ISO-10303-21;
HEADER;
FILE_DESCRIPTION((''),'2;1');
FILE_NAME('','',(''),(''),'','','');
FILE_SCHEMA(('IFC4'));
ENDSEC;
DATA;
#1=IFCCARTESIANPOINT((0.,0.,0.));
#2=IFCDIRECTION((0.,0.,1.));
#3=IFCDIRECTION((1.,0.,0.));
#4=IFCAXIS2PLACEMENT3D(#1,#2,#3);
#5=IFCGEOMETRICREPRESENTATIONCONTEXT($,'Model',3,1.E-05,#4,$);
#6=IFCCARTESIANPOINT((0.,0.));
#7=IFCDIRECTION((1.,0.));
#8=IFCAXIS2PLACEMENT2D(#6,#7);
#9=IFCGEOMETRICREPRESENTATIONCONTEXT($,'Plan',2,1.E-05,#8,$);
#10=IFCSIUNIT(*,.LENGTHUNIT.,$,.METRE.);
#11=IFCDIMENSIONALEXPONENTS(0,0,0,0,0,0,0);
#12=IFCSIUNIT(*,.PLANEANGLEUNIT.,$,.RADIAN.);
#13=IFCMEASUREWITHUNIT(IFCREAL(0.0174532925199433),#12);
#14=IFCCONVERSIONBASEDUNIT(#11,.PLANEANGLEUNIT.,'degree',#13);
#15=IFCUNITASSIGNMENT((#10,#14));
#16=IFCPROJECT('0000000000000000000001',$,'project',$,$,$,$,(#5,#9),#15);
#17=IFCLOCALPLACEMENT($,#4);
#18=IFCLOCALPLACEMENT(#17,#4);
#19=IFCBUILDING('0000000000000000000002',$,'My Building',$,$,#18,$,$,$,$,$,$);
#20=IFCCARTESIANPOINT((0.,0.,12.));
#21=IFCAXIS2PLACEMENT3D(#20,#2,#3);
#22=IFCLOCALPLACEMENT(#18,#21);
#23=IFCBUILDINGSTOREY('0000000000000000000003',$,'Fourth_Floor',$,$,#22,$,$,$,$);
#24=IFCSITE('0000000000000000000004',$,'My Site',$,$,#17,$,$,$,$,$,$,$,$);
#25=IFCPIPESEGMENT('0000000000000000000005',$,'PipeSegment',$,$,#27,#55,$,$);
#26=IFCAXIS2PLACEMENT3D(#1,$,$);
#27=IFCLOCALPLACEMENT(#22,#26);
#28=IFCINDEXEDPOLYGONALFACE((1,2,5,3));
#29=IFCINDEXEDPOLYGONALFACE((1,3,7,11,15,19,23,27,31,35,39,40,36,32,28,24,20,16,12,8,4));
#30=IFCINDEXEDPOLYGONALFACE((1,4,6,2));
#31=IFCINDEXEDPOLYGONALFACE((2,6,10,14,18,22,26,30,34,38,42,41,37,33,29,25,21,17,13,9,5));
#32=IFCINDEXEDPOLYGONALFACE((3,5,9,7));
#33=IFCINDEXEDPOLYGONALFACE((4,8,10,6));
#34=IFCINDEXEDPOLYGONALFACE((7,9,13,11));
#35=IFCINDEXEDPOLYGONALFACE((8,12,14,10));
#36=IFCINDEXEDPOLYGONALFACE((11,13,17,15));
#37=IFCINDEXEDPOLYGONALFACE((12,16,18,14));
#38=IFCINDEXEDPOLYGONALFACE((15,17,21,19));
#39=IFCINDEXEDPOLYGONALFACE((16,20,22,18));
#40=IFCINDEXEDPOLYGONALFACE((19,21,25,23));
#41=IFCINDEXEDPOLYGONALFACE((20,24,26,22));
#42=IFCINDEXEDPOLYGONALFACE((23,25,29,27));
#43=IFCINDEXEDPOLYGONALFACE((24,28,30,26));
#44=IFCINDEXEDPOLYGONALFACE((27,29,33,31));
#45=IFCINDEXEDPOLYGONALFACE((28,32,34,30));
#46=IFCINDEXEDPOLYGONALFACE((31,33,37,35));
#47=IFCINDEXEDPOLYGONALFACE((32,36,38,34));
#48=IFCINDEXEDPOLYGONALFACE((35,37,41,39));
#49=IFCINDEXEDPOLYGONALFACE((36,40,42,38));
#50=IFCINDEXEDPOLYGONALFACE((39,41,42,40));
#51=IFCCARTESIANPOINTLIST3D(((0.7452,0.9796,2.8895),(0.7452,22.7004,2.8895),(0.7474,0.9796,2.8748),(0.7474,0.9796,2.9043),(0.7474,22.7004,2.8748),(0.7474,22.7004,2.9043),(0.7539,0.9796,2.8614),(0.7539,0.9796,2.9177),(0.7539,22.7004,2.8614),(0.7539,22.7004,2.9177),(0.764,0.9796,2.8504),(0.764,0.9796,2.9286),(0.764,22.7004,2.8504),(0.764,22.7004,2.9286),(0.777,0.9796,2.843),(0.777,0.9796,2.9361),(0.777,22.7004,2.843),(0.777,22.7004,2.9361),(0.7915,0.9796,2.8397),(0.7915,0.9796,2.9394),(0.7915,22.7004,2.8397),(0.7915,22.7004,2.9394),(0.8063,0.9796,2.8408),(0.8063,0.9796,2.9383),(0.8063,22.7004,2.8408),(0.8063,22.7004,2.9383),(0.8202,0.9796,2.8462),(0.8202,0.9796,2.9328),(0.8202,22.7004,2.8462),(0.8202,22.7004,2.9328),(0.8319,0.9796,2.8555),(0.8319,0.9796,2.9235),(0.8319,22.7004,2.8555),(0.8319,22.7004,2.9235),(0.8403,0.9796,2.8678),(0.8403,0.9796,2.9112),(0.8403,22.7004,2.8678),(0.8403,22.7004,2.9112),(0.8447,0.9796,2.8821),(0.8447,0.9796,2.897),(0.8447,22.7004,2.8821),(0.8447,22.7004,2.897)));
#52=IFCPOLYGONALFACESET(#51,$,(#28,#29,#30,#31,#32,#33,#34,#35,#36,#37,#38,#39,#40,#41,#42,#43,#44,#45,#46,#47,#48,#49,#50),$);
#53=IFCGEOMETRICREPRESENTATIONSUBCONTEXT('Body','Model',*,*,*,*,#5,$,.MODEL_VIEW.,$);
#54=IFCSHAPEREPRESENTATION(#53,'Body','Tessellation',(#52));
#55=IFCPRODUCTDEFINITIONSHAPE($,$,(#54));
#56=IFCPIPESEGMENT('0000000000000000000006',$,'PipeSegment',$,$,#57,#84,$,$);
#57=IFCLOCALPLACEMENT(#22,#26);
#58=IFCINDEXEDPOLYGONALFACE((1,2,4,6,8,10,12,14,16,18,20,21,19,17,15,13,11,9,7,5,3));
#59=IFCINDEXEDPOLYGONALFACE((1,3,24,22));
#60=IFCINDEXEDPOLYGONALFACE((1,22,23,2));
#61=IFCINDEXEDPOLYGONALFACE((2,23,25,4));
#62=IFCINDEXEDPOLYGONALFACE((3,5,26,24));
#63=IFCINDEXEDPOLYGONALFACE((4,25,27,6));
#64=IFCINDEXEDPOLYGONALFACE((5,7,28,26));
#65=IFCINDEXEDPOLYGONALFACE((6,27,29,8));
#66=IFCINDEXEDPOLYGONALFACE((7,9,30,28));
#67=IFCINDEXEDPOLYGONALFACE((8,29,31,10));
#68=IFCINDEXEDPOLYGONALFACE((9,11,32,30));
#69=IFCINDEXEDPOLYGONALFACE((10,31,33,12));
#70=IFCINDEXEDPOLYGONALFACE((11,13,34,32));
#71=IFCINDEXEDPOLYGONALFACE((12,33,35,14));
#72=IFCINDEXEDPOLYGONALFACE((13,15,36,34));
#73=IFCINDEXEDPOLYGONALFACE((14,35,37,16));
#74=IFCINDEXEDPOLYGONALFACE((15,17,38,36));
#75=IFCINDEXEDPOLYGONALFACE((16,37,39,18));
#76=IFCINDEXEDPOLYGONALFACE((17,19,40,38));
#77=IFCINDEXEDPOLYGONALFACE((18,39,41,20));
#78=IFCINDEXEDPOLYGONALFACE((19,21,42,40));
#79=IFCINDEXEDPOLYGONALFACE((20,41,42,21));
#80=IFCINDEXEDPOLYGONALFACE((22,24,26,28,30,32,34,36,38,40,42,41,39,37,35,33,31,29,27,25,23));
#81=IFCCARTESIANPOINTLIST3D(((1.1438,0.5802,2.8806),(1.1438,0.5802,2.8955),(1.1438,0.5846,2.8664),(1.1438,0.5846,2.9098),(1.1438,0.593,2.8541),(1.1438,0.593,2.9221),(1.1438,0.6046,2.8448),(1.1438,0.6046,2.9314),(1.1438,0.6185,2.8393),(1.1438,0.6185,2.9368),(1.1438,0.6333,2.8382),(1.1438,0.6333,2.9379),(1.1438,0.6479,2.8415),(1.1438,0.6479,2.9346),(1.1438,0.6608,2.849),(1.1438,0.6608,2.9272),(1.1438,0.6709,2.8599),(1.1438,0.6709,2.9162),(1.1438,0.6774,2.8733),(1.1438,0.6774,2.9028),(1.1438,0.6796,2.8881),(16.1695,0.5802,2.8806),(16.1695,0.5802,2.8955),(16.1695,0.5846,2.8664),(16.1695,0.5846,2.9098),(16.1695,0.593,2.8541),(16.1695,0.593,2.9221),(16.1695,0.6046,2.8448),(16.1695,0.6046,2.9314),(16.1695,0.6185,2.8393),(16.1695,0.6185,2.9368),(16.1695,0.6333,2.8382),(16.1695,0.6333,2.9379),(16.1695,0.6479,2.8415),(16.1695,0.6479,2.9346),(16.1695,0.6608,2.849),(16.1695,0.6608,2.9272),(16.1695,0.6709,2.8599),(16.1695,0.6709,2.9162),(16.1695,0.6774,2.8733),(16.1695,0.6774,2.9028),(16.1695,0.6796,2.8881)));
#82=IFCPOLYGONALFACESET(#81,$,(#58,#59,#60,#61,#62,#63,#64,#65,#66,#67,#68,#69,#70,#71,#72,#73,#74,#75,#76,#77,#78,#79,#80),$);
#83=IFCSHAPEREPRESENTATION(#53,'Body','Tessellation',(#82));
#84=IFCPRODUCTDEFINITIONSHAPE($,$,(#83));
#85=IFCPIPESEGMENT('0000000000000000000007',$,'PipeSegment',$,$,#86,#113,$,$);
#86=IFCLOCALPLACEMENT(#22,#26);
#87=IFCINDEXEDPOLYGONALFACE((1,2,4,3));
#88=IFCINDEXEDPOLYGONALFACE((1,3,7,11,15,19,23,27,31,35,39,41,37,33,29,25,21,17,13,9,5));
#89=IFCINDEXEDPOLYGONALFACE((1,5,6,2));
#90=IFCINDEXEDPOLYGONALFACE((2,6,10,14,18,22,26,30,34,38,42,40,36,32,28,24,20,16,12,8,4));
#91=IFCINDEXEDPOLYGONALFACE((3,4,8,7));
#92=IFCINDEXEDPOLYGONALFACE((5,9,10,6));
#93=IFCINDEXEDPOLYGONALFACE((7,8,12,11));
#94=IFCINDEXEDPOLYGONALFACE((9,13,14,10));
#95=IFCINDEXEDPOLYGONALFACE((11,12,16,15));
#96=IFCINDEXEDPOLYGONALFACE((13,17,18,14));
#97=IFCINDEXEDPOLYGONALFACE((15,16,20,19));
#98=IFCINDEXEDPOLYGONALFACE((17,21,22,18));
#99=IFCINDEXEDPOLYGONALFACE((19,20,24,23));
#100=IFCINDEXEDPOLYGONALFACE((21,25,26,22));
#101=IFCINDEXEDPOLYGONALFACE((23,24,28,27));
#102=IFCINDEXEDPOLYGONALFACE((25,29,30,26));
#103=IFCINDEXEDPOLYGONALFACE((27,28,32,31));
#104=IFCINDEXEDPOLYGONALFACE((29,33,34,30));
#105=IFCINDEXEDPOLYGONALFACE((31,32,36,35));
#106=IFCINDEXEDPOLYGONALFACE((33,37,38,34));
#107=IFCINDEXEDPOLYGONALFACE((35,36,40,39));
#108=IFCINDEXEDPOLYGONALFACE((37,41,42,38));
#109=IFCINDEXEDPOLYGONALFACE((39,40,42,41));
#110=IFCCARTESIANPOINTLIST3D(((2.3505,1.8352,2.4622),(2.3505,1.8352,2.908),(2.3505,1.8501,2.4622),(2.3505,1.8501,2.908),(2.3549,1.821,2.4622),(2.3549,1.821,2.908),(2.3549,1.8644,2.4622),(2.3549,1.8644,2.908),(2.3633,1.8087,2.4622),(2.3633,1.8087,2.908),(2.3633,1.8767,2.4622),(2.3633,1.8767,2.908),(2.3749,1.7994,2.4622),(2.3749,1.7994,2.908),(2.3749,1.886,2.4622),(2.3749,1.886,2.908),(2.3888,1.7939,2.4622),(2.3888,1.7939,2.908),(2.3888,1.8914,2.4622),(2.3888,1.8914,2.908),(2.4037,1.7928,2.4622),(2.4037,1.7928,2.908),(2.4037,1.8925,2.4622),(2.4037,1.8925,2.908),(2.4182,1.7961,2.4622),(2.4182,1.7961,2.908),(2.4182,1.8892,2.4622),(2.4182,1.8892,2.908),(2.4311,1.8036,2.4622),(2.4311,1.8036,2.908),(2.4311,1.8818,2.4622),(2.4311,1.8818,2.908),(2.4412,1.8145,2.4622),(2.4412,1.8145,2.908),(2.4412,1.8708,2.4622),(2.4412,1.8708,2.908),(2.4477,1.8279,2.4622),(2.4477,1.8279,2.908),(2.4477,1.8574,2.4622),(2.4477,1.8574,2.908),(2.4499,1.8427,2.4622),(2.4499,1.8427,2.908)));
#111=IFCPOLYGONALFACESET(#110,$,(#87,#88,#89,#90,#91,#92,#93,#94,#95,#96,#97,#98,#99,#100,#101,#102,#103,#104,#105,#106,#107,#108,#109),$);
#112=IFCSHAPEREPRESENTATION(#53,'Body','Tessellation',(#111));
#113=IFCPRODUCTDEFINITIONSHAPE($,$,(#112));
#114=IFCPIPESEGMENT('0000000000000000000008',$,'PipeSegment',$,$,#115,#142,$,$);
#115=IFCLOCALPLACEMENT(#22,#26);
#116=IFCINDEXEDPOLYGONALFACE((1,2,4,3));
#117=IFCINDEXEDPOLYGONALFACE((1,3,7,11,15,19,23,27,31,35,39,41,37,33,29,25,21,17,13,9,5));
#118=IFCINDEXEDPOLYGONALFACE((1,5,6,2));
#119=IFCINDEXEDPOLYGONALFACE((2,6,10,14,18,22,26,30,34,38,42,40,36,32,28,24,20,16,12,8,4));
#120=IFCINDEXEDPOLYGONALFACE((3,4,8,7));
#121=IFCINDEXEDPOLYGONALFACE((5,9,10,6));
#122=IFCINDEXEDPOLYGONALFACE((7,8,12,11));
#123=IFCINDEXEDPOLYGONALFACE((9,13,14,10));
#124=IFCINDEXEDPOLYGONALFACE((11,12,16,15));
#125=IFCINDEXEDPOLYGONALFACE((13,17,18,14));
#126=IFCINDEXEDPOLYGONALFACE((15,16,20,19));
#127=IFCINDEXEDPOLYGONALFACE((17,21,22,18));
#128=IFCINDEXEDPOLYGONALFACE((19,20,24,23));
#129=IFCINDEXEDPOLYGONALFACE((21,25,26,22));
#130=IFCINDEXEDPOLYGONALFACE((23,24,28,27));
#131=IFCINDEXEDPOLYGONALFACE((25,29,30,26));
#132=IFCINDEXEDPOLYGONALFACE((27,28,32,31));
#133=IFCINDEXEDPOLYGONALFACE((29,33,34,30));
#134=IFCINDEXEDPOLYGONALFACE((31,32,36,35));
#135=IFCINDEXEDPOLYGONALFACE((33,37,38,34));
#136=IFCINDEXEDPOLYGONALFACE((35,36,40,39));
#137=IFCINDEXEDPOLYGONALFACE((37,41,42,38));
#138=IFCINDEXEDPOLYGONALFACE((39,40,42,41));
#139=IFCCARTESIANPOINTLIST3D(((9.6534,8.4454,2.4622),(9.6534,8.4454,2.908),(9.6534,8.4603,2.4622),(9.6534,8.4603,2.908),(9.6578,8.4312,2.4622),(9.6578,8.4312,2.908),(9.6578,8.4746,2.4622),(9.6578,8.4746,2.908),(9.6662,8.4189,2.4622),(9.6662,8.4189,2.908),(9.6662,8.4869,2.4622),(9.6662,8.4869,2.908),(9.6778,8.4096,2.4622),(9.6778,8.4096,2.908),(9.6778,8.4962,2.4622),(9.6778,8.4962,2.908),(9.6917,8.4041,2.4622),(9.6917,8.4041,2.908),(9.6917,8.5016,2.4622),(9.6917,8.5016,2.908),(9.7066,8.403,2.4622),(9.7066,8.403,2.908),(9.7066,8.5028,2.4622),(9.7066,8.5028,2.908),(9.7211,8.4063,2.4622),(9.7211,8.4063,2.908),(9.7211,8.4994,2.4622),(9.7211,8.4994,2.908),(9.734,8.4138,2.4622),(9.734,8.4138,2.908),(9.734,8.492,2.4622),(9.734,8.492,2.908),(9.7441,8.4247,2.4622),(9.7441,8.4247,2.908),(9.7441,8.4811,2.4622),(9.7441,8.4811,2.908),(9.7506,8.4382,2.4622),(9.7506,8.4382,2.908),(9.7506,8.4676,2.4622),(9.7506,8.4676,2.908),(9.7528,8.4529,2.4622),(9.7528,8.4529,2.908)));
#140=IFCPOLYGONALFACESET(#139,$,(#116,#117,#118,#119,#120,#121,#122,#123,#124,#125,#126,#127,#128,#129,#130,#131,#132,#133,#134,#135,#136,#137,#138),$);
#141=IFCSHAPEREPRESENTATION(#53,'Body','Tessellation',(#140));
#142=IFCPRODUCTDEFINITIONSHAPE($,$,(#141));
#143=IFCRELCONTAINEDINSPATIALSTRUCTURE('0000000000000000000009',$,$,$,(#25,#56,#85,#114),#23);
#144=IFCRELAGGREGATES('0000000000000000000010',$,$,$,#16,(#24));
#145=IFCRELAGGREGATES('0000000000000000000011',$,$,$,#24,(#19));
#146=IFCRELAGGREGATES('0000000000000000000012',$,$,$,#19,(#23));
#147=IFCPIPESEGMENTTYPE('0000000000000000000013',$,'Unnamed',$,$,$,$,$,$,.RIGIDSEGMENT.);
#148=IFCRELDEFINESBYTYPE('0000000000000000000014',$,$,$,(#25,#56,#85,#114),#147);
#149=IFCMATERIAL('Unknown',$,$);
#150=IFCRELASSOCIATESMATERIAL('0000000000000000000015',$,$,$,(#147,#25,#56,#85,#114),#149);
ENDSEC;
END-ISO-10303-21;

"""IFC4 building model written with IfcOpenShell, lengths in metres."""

from ifc_helpers import new_model, entity, si_unit, converted_unit, frame, origin_with_axes, origin_2d_with_axis, place, context, subcontext, project, spatial, circle, extrude, material, material_profile, profile_set, profile_usage, type_object, element, save


model = new_model("IFC4")

# Units and contexts
model_context = context("Model", 3, precision=1e-05, world=origin_with_axes())
plan_context = context("Plan", 2, precision=1e-05, world=origin_2d_with_axis())
body_context_1 = subcontext(model_context, "Body", "Model", "MODEL_VIEW")
ifc_project = project(units=[si_unit("LENGTHUNIT", "METRE"), converted_unit("PLANEANGLEUNIT", "degree", entity("IfcReal", 0.0174532925199433), si_unit("PLANEANGLEUNIT", "RADIAN"), dimensions=[0, 0, 0, 0, 0, 0, 0])], contexts=[model_context, plan_context])

# Site, building, storey
site_placement = place(None, origin_with_axes())
site = spatial("IfcSite", under=ifc_project, at=site_placement, Name="My Site")
building_placement = place(site_placement, origin_with_axes())
building = spatial("IfcBuilding", under=site, at=building_placement, Name="My Building")
storey_placement = place(building_placement, frame((0.0, 0.0, 12.0), z_axis=(0.0, 0.0, 1.0), x_axis=(1.0, 0.0, 0.0)))
storey = spatial("IfcBuildingStorey", under=building, at=storey_placement, Name="Fourth_Floor")

# Shared definitions
ifc_material = material(Name="Unknown")

# Pipe segments
ifc_material_profile_1 = material_profile(ifc_material, circle(Radius=0.05))
ifc_profile_set_1 = profile_set([ifc_material_profile_1])
pipe_segment_type = type_object("IfcPipeSegmentType", Name="Unnamed", PredefinedType="RIGIDSEGMENT", material=ifc_profile_set_1)
ifc_profile_usage_1 = profile_usage(ifc_profile_set_1, cardinal=5)
pipe_segment_1_placement = place(storey_placement, frame((0.7952, 0.9796, 2.8895), z_axis=(0.0, 1.0, 0.0), x_axis=(-1.0, 0.0, 0.0)))
element("IfcPipeSegment", 1, at=pipe_segment_1_placement, inside=storey, type_object=pipe_segment_type, material=ifc_profile_usage_1, Name="PipeSegment", context=body_context_1, shape_type="SweptSolid", body=[
    extrude(circle(Radius=0.05), origin_with_axes(), (0.0, 0.0, 1.0), 21.7208),
])
ifc_profile_usage_2 = profile_usage(ifc_profile_set_1, cardinal=5)
pipe_segment_2_placement = place(storey_placement, frame((1.1438, 0.6296, 2.8881), z_axis=(1.0, 0.0, 0.0), x_axis=(0.0, 1.0, 0.0)))
element("IfcPipeSegment", 2, at=pipe_segment_2_placement, inside=storey, type_object=pipe_segment_type, material=ifc_profile_usage_2, Name="PipeSegment", context=body_context_1, shape_type="SweptSolid", body=[
    extrude(circle(Radius=0.05), origin_with_axes(), (0.0, 0.0, 1.0), 15.0257),
])
ifc_profile_usage_3 = profile_usage(ifc_profile_set_1, cardinal=5)
pipe_segment_3_placement = place(storey_placement, frame((2.3999, 1.8427, 2.908), z_axis=(0.0, 0.0, -1.0), x_axis=(1.0, 0.0, 0.0)))
element("IfcPipeSegment", 3, at=pipe_segment_3_placement, inside=storey, type_object=pipe_segment_type, material=ifc_profile_usage_3, Name="PipeSegment", context=body_context_1, shape_type="SweptSolid", body=[
    extrude(circle(Radius=0.05), origin_with_axes(), (0.0, 0.0, 1.0), 0.4458),
])
ifc_profile_usage_4 = profile_usage(ifc_profile_set_1, cardinal=5)
pipe_segment_4_placement = place(storey_placement, frame((9.7028, 8.4529, 2.908), z_axis=(0.0, 0.0, -1.0), x_axis=(1.0, 0.0, 0.0)))
element("IfcPipeSegment", 4, at=pipe_segment_4_placement, inside=storey, type_object=pipe_segment_type, material=ifc_profile_usage_4, Name="PipeSegment", context=body_context_1, shape_type="SweptSolid", body=[
    extrude(circle(Radius=0.05), origin_with_axes(), (0.0, 0.0, 1.0), 0.4458),
])

save(model, "model.ifc")
